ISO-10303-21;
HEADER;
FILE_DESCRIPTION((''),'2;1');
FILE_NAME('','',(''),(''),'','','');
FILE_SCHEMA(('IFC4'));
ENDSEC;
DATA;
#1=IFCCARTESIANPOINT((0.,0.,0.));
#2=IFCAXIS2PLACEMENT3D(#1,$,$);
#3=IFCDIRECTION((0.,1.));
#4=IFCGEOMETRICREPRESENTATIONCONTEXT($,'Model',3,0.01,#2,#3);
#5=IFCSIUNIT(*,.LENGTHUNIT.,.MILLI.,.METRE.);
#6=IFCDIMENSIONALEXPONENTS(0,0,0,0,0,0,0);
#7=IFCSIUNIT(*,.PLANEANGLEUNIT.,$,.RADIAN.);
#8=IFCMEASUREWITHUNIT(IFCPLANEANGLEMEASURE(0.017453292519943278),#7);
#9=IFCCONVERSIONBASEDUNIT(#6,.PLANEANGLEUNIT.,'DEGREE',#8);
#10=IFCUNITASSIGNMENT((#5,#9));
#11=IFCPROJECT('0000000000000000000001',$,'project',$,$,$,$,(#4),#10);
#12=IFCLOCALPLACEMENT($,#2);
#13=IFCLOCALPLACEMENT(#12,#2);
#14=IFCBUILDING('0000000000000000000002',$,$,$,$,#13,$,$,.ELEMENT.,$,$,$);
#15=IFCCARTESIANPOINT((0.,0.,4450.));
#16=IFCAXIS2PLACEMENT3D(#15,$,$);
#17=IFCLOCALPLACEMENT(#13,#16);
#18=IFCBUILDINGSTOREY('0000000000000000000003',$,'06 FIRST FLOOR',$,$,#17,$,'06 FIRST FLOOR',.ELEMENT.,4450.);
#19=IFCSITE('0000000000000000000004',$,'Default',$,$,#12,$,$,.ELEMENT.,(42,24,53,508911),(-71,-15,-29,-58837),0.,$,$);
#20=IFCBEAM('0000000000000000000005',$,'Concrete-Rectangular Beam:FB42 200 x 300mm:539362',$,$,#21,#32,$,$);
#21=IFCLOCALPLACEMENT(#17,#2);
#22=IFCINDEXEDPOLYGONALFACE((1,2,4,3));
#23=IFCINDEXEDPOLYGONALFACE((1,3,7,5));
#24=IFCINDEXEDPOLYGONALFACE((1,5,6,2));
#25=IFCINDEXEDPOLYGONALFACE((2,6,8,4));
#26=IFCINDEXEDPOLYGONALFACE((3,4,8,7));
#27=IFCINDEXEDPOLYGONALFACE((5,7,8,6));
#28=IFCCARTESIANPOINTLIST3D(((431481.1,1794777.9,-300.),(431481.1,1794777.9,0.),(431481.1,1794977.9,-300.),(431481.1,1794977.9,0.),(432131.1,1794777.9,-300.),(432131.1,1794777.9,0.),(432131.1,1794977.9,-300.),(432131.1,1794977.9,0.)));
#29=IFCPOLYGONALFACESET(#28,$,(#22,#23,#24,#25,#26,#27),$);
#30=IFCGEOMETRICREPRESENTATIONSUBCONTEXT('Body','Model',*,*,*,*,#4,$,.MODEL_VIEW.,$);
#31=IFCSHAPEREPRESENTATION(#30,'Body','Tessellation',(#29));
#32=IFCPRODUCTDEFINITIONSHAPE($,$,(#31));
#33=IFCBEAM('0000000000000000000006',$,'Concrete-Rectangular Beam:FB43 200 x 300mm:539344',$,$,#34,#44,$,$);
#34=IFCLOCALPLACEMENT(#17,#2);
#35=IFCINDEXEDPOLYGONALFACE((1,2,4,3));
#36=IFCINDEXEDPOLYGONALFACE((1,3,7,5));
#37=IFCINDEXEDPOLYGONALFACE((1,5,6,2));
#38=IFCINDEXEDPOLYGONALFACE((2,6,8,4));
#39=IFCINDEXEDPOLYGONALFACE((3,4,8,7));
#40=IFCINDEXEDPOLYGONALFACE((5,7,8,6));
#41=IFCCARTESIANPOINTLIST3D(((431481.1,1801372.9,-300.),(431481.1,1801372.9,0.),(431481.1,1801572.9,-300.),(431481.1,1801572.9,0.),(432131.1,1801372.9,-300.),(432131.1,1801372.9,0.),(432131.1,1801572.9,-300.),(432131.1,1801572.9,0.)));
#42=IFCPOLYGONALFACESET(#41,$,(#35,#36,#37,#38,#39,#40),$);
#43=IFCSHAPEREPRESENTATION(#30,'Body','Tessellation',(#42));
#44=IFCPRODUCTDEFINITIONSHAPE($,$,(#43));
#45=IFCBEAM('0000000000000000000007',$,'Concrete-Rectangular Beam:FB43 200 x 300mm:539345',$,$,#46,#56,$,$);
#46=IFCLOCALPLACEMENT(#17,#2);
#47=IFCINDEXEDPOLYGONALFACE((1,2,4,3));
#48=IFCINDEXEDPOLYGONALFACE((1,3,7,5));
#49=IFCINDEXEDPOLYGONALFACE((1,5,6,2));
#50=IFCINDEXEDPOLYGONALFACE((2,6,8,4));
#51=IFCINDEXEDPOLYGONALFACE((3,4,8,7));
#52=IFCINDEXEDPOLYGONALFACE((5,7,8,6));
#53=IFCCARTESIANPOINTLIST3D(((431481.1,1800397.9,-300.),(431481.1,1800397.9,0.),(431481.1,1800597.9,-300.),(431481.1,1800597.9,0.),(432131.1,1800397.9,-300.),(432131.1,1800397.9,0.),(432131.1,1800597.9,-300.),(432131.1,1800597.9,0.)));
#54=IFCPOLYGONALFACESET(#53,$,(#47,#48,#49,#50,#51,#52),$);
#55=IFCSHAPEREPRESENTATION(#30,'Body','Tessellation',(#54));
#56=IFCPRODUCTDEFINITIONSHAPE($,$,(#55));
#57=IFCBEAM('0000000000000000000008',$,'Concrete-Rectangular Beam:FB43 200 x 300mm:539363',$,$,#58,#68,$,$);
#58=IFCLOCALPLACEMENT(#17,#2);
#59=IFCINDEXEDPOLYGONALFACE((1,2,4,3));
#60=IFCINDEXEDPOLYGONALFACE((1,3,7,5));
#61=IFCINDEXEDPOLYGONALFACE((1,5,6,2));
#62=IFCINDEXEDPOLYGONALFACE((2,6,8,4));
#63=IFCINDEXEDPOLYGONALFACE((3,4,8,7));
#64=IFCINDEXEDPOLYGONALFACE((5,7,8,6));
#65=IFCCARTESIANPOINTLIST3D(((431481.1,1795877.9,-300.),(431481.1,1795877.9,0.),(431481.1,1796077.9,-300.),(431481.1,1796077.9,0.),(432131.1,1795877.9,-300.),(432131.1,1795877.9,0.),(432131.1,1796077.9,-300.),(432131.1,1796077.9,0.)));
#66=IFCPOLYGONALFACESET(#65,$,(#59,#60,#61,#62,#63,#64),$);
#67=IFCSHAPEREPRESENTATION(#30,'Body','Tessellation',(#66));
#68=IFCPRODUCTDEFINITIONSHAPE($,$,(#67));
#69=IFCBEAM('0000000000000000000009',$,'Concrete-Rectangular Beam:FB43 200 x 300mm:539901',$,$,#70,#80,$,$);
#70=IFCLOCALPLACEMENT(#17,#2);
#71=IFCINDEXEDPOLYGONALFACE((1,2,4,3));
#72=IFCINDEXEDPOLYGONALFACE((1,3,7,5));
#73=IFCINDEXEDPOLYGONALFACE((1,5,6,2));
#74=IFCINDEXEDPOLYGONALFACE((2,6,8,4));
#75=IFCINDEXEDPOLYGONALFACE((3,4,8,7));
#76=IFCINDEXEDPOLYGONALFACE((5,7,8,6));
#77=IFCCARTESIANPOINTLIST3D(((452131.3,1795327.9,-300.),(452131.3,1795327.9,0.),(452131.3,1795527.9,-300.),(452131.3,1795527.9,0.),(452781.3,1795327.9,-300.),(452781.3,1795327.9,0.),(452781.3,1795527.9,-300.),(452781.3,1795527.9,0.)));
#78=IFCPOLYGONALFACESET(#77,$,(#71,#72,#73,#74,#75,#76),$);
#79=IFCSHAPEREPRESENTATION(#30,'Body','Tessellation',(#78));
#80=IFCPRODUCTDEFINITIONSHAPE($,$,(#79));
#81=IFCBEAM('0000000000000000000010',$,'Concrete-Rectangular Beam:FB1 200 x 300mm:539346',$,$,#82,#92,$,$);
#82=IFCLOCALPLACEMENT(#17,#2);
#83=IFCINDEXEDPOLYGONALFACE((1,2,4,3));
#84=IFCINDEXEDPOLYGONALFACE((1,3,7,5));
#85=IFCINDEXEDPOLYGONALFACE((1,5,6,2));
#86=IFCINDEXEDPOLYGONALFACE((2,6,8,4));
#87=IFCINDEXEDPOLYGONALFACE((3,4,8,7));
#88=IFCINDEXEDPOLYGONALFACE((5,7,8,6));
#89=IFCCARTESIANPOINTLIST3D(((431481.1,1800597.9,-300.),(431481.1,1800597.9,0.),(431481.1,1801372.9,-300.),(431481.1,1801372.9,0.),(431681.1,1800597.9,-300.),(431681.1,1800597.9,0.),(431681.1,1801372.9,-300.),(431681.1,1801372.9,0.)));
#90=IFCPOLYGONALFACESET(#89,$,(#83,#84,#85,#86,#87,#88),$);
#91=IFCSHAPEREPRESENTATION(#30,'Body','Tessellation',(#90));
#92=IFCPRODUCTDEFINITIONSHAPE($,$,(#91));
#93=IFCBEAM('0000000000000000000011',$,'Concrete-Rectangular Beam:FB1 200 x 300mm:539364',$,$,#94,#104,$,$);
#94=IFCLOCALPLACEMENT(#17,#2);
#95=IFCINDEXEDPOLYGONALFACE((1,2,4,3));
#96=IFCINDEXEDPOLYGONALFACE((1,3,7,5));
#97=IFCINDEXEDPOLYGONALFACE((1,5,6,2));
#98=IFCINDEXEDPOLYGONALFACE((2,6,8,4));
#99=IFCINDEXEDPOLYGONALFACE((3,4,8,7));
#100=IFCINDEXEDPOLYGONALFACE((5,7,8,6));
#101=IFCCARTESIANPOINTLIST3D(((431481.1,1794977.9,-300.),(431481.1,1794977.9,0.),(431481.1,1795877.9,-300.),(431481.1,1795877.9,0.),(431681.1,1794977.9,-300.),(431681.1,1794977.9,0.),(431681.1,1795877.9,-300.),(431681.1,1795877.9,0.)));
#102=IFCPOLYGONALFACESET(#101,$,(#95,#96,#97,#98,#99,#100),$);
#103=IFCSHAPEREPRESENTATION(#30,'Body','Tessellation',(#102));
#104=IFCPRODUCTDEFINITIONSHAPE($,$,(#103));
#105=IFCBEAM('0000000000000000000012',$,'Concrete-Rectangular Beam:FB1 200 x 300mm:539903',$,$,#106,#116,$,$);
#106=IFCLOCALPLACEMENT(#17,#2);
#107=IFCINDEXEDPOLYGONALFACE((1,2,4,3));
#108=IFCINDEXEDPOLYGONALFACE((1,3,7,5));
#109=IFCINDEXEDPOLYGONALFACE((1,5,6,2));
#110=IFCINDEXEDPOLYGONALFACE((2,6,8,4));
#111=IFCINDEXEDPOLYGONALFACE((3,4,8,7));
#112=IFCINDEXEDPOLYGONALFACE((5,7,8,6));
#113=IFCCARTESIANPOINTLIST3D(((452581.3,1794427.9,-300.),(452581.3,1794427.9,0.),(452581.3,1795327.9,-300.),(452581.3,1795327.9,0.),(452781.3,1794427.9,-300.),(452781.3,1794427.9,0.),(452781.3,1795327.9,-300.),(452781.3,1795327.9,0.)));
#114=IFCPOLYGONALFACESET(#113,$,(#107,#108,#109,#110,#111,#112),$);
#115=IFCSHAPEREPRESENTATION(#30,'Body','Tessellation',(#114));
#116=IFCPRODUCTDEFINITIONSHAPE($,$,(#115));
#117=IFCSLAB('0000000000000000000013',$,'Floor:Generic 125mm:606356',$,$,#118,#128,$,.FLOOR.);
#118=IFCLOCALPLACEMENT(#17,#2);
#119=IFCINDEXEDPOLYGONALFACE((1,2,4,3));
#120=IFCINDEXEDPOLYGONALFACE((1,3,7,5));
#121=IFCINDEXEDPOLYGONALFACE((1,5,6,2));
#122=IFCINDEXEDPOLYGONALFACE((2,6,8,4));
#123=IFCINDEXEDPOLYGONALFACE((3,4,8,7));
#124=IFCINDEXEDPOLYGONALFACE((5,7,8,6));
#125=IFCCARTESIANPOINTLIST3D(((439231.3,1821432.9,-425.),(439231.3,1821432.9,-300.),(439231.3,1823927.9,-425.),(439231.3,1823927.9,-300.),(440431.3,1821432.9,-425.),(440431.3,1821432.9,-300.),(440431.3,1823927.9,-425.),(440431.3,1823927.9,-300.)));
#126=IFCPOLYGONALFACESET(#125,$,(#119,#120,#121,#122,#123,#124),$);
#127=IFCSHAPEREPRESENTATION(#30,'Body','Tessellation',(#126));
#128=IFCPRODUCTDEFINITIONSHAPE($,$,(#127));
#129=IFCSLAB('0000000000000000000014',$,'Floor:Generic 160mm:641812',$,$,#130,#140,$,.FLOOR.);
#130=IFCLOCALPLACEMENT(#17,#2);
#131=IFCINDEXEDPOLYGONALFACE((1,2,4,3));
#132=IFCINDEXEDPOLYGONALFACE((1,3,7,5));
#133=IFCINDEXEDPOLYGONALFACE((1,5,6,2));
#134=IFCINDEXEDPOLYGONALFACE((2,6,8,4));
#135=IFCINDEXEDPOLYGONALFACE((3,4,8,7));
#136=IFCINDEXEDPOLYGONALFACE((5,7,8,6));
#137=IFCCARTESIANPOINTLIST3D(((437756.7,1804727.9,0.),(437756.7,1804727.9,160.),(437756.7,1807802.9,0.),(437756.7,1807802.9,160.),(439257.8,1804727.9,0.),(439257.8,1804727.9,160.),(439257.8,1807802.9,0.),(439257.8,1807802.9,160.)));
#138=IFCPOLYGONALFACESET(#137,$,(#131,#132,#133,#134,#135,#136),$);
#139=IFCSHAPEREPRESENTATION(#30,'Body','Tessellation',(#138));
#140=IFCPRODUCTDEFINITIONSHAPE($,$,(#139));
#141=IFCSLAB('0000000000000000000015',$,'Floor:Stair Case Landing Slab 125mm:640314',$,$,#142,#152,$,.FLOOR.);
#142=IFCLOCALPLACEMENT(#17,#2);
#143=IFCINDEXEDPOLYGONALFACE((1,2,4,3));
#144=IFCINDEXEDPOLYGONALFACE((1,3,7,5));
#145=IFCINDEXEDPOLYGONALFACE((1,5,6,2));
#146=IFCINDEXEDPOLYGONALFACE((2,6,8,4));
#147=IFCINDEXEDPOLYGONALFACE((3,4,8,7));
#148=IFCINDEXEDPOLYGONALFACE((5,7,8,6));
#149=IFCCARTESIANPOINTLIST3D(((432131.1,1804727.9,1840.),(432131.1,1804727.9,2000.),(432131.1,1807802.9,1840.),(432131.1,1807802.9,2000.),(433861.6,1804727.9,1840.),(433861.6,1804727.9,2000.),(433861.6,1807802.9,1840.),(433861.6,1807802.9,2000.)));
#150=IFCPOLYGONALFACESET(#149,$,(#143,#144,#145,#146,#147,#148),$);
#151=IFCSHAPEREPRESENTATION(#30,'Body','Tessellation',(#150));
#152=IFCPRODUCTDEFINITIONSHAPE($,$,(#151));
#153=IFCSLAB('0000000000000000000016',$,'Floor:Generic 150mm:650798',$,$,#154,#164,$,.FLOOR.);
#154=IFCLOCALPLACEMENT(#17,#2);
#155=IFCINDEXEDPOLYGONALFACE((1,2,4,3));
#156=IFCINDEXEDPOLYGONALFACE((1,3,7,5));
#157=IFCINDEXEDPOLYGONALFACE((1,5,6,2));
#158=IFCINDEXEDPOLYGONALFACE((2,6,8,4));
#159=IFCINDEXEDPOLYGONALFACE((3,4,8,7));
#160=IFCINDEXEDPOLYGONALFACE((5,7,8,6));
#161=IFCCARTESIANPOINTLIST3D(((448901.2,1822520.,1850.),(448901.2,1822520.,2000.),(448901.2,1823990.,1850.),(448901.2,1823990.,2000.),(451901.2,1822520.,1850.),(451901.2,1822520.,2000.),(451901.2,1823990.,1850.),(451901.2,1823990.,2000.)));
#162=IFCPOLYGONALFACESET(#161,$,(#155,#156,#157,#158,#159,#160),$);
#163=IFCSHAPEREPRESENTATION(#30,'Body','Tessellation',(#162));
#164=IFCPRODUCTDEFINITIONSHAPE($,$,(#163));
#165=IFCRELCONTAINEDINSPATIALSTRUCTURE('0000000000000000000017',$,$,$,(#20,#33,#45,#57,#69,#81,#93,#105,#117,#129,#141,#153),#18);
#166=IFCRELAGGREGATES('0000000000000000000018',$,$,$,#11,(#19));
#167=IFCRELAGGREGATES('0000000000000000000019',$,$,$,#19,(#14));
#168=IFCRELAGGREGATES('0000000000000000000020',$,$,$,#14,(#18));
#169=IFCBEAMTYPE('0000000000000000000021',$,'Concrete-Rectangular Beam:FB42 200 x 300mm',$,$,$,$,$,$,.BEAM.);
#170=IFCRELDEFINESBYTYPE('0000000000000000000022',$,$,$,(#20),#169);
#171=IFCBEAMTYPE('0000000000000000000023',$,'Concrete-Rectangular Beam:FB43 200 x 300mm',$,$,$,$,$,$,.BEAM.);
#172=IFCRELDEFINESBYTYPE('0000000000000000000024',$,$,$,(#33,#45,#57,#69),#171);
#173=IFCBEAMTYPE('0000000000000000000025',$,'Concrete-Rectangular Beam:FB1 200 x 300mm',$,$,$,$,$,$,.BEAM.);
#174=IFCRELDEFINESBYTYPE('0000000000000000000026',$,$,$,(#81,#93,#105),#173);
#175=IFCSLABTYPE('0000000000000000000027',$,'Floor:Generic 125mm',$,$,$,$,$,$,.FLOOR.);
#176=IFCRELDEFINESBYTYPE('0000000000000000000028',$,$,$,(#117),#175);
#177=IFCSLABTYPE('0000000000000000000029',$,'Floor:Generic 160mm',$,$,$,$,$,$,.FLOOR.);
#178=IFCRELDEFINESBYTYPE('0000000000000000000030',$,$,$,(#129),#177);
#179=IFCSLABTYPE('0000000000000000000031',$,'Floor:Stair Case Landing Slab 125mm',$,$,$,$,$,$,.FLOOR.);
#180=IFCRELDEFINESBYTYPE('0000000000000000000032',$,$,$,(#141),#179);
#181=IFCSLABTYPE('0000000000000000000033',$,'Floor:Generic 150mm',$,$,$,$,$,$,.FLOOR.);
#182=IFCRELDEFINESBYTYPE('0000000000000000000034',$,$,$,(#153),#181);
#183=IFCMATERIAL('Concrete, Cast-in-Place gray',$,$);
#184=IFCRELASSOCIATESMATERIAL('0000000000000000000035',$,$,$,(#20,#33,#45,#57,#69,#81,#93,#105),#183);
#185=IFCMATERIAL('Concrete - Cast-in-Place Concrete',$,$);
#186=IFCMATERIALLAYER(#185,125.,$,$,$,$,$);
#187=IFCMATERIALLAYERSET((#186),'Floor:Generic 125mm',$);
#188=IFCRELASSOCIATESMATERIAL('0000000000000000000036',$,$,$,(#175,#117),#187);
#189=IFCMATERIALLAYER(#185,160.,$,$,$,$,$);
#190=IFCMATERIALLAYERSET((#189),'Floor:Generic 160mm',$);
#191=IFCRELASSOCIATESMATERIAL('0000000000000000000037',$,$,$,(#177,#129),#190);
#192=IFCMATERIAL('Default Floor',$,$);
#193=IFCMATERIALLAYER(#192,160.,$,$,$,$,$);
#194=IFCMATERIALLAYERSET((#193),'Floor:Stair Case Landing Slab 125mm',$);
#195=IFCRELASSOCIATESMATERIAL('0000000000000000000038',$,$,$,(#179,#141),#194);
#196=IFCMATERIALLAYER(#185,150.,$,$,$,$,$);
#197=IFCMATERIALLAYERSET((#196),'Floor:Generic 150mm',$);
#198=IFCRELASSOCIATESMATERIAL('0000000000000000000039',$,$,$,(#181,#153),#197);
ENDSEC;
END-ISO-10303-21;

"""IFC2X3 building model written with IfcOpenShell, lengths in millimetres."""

from ifc_helpers import new_model, entity, si_unit, converted_unit, direction, frame, frame_2d, origin, origin_2d_with_axis, place, context, subcontext, project, spatial, rectangle, extrude, material, layer, layer_set, layer_usage, type_object, element, save


model = new_model("IFC2X3")

# Units and contexts
model_context = context("Model", 3, precision=0.01, world=origin(), true_north=direction((0.0, 1.0)))
body_context = subcontext(model_context, "Body", "Model", "MODEL_VIEW")
ifc_project = project(units=[si_unit("LENGTHUNIT", "METRE", prefix="MILLI"), converted_unit("PLANEANGLEUNIT", "DEGREE", entity("IfcPlaneAngleMeasure", 0.017453292519943278), si_unit("PLANEANGLEUNIT", "RADIAN"), dimensions=[0, 0, 0, 0, 0, 0, 0])], contexts=[model_context])

# Site, building, storey
site_placement = place(None, origin())
site = spatial("IfcSite", under=ifc_project, at=site_placement, Name="Default", CompositionType="ELEMENT", RefLatitude=(42, 24, 53, 508911), RefLongitude=(-71, -15, -29, -58837), RefElevation=0.0)
building_placement = place(site_placement, origin())
building = spatial("IfcBuilding", under=site, at=building_placement, CompositionType="ELEMENT")
storey_placement = place(building_placement, frame((0.0, 0.0, 4450.0)))
storey = spatial("IfcBuildingStorey", under=building, at=storey_placement, Name="06 FIRST FLOOR", LongName="06 FIRST FLOOR", CompositionType="ELEMENT", Elevation=4450.0)

# Beams
ifc_material_1 = material(Name="Concrete, Cast-in-Place gray")
beam_type_1 = type_object("IfcBeamType", Name="Concrete-Rectangular Beam:FB42 200 x 300mm", PredefinedType="BEAM")
beam_1_placement = place(storey_placement, frame((431481.1, 1794777.9, 0.0)))
element("IfcBeam", 1, at=beam_1_placement, inside=storey, type_object=beam_type_1, material=ifc_material_1, Name="Concrete-Rectangular Beam:FB42 200 x 300mm:539362", context=body_context, shape_type="SweptSolid", body=[
    extrude(rectangle(XDim=300.0, YDim=200.0, at=origin_2d_with_axis()), frame((0.0, 100.0, -150.0), z_axis=(1.0, 0.0, 0.0), x_axis=(0.0, 0.0, -1.0)), (0.0, 0.0, 1.0), 650.0),
])
beam_type_2 = type_object("IfcBeamType", Name="Concrete-Rectangular Beam:FB43 200 x 300mm", PredefinedType="BEAM")
beam_2_placement = place(storey_placement, frame((431681.1, 1801372.9, 0.0)))
element("IfcBeam", 2, at=beam_2_placement, inside=storey, type_object=beam_type_2, material=ifc_material_1, Name="Concrete-Rectangular Beam:FB43 200 x 300mm:539344", context=body_context, shape_type="SweptSolid", body=[
    extrude(rectangle(XDim=300.0, YDim=200.0, at=origin_2d_with_axis()), frame((-200.0, 100.0, -150.0), z_axis=(1.0, 0.0, 0.0), x_axis=(0.0, 0.0, -1.0)), (0.0, 0.0, 1.0), 650.0),
])
beam_3_placement = place(storey_placement, frame((431681.1, 1800597.9, 0.0)))
element("IfcBeam", 3, at=beam_3_placement, inside=storey, type_object=beam_type_2, material=ifc_material_1, Name="Concrete-Rectangular Beam:FB43 200 x 300mm:539345", context=body_context, shape_type="SweptSolid", body=[
    extrude(rectangle(XDim=300.0, YDim=200.0, at=origin_2d_with_axis()), frame((-200.0, -100.0, -150.0), z_axis=(1.0, 0.0, 0.0), x_axis=(0.0, 0.0, -1.0)), (0.0, 0.0, 1.0), 650.0),
])
beam_4_placement = place(storey_placement, frame((431481.1, 1796077.9, 0.0)))
element("IfcBeam", 4, at=beam_4_placement, inside=storey, type_object=beam_type_2, material=ifc_material_1, Name="Concrete-Rectangular Beam:FB43 200 x 300mm:539363", context=body_context, shape_type="SweptSolid", body=[
    extrude(rectangle(XDim=300.0, YDim=200.0, at=origin_2d_with_axis()), frame((0.0, -100.0, -150.0), z_axis=(1.0, 0.0, 0.0), x_axis=(0.0, 0.0, -1.0)), (0.0, 0.0, 1.0), 650.0),
])
beam_5_placement = place(storey_placement, frame((452781.3, 1795527.9, 0.0), z_axis=(0.0, 0.0, 1.0), x_axis=(-1.0, 0.0, 0.0)))
element("IfcBeam", 5, at=beam_5_placement, inside=storey, type_object=beam_type_2, material=ifc_material_1, Name="Concrete-Rectangular Beam:FB43 200 x 300mm:539901", context=body_context, shape_type="SweptSolid", body=[
    extrude(rectangle(XDim=300.0, YDim=200.0, at=origin_2d_with_axis()), frame((0.0, 100.0, -150.0), z_axis=(1.0, 0.0, 0.0), x_axis=(0.0, 0.0, -1.0)), (0.0, 0.0, 1.0), 650.0),
])
beam_type_3 = type_object("IfcBeamType", Name="Concrete-Rectangular Beam:FB1 200 x 300mm", PredefinedType="BEAM")
beam_6_placement = place(storey_placement, frame((431681.1, 1801372.9, 0.0), z_axis=(0.0, 0.0, 1.0), x_axis=(0.0, -1.0, 0.0)))
element("IfcBeam", 6, at=beam_6_placement, inside=storey, type_object=beam_type_3, material=ifc_material_1, Name="Concrete-Rectangular Beam:FB1 200 x 300mm:539346", context=body_context, shape_type="SweptSolid", body=[
    extrude(rectangle(XDim=300.0, YDim=200.0, at=origin_2d_with_axis()), frame((0.0, -100.0, -150.0), z_axis=(1.0, 0.0, 0.0), x_axis=(0.0, 0.0, -1.0)), (0.0, 0.0, 1.0), 775.0),
])
beam_7_placement = place(storey_placement, frame((431481.1, 1794777.9, 0.0), z_axis=(0.0, 0.0, 1.0), x_axis=(0.0, 1.0, 0.0)))
element("IfcBeam", 7, at=beam_7_placement, inside=storey, type_object=beam_type_3, material=ifc_material_1, Name="Concrete-Rectangular Beam:FB1 200 x 300mm:539364", context=body_context, shape_type="SweptSolid", body=[
    extrude(rectangle(XDim=300.0, YDim=200.0, at=origin_2d_with_axis()), frame((200.0, -100.0, -150.0), z_axis=(1.0, 0.0, 0.0), x_axis=(0.0, 0.0, -1.0)), (0.0, 0.0, 1.0), 900.0),
])
beam_8_placement = place(storey_placement, frame((452781.3, 1795527.9, 0.0), z_axis=(0.0, 0.0, 1.0), x_axis=(0.0, -1.0, 0.0)))
element("IfcBeam", 8, at=beam_8_placement, inside=storey, type_object=beam_type_3, material=ifc_material_1, Name="Concrete-Rectangular Beam:FB1 200 x 300mm:539903", context=body_context, shape_type="SweptSolid", body=[
    extrude(rectangle(XDim=300.0, YDim=200.0, at=frame_2d((0.0, 0.0), x_axis=(1.0, 0.0))), frame((200.0, -100.0, -150.0), z_axis=(1.0, 0.0, 0.0), x_axis=(0.0, 0.0, -1.0)), (0.0, 0.0, 1.0), 900.0),
])

# Shared definitions
ifc_material_2 = material(Name="Concrete - Cast-in-Place Concrete")
ifc_layer_1 = layer(ifc_material_2, 125.0)
ifc_layer_set_1 = layer_set([ifc_layer_1], Name="Floor:Generic 125mm")
slab_type_1 = type_object("IfcSlabType", Name="Floor:Generic 125mm", PredefinedType="FLOOR", material=ifc_layer_set_1)

# Slabs
ifc_layer_usage_1 = layer_usage(ifc_layer_set_1, "AXIS3", "POSITIVE", 0.0)
slab_1_placement = place(storey_placement, origin())
element("IfcSlab", 9, at=slab_1_placement, inside=storey, type_object=slab_type_1, material=ifc_layer_usage_1, Name="Floor:Generic 125mm:606356", PredefinedType="FLOOR", context=body_context, shape_type="SweptSolid", body=[
    extrude(rectangle(XDim=2495.0, YDim=1200.0, at=frame_2d((0.0, 0.0), x_axis=(1.0, 0.0))), frame((439831.3, 1822680.4, -300.0), z_axis=(0.0, 0.0, -1.0), x_axis=(0.0, 1.0, 0.0)), (0.0, 0.0, 1.0), 125.0),
])
ifc_layer_2 = layer(ifc_material_2, 160.0)
ifc_layer_set_2 = layer_set([ifc_layer_2], Name="Floor:Generic 160mm")
ifc_layer_usage_2 = layer_usage(ifc_layer_set_2, "AXIS3", "POSITIVE", 0.0)
slab_type_2 = type_object("IfcSlabType", Name="Floor:Generic 160mm", PredefinedType="FLOOR", material=ifc_layer_set_2)
slab_2_placement = place(storey_placement, origin())
element("IfcSlab", 10, at=slab_2_placement, inside=storey, type_object=slab_type_2, material=ifc_layer_usage_2, Name="Floor:Generic 160mm:641812", PredefinedType="FLOOR", context=body_context, shape_type="SweptSolid", body=[
    extrude(rectangle(XDim=3075.0, YDim=1501.1, at=frame_2d((0.0, 0.0), x_axis=(1.0, 0.0))), frame((438507.2, 1806265.4, 160.0), z_axis=(0.0, 0.0, -1.0), x_axis=(0.0, 1.0, 0.0)), (0.0, 0.0, 1.0), 160.0),
])
ifc_material_3 = material(Name="Default Floor")
ifc_layer_3 = layer(ifc_material_3, 160.0)
ifc_layer_set_3 = layer_set([ifc_layer_3], Name="Floor:Stair Case Landing Slab 125mm")
ifc_layer_usage_3 = layer_usage(ifc_layer_set_3, "AXIS3", "POSITIVE", 0.0)
slab_type_3 = type_object("IfcSlabType", Name="Floor:Stair Case Landing Slab 125mm", PredefinedType="FLOOR", material=ifc_layer_set_3)
slab_3_placement = place(storey_placement, origin())
element("IfcSlab", 11, at=slab_3_placement, inside=storey, type_object=slab_type_3, material=ifc_layer_usage_3, Name="Floor:Stair Case Landing Slab 125mm:640314", PredefinedType="FLOOR", context=body_context, shape_type="SweptSolid", body=[
    extrude(rectangle(XDim=3075.0, YDim=1730.5, at=frame_2d((0.0, 0.0), x_axis=(1.0, 0.0))), frame((432996.4, 1806265.4, 2000.0), z_axis=(0.0, 0.0, -1.0), x_axis=(0.0, 1.0, 0.0)), (0.0, 0.0, 1.0), 160.0),
])

# Slab
ifc_layer_4 = layer(ifc_material_2, 150.0)
ifc_layer_set_4 = layer_set([ifc_layer_4], Name="Floor:Generic 150mm")
ifc_layer_usage_4 = layer_usage(ifc_layer_set_4, "AXIS3", "POSITIVE", 0.0)
slab_type_4 = type_object("IfcSlabType", Name="Floor:Generic 150mm", PredefinedType="FLOOR", material=ifc_layer_set_4)
slab_4_placement = place(storey_placement, origin())
element("IfcSlab", 12, at=slab_4_placement, inside=storey, type_object=slab_type_4, material=ifc_layer_usage_4, Name="Floor:Generic 150mm:650798", PredefinedType="FLOOR", context=body_context, shape_type="SweptSolid", body=[
    extrude(rectangle(XDim=1470.0, YDim=3000.0, at=frame_2d((0.0, 0.0), x_axis=(1.0, 0.0))), frame((450401.2, 1823255.0, 2000.0), z_axis=(0.0, 0.0, -1.0), x_axis=(0.0, 1.0, 0.0)), (0.0, 0.0, 1.0), 150.0),
])

save(model, "model.ifc")
